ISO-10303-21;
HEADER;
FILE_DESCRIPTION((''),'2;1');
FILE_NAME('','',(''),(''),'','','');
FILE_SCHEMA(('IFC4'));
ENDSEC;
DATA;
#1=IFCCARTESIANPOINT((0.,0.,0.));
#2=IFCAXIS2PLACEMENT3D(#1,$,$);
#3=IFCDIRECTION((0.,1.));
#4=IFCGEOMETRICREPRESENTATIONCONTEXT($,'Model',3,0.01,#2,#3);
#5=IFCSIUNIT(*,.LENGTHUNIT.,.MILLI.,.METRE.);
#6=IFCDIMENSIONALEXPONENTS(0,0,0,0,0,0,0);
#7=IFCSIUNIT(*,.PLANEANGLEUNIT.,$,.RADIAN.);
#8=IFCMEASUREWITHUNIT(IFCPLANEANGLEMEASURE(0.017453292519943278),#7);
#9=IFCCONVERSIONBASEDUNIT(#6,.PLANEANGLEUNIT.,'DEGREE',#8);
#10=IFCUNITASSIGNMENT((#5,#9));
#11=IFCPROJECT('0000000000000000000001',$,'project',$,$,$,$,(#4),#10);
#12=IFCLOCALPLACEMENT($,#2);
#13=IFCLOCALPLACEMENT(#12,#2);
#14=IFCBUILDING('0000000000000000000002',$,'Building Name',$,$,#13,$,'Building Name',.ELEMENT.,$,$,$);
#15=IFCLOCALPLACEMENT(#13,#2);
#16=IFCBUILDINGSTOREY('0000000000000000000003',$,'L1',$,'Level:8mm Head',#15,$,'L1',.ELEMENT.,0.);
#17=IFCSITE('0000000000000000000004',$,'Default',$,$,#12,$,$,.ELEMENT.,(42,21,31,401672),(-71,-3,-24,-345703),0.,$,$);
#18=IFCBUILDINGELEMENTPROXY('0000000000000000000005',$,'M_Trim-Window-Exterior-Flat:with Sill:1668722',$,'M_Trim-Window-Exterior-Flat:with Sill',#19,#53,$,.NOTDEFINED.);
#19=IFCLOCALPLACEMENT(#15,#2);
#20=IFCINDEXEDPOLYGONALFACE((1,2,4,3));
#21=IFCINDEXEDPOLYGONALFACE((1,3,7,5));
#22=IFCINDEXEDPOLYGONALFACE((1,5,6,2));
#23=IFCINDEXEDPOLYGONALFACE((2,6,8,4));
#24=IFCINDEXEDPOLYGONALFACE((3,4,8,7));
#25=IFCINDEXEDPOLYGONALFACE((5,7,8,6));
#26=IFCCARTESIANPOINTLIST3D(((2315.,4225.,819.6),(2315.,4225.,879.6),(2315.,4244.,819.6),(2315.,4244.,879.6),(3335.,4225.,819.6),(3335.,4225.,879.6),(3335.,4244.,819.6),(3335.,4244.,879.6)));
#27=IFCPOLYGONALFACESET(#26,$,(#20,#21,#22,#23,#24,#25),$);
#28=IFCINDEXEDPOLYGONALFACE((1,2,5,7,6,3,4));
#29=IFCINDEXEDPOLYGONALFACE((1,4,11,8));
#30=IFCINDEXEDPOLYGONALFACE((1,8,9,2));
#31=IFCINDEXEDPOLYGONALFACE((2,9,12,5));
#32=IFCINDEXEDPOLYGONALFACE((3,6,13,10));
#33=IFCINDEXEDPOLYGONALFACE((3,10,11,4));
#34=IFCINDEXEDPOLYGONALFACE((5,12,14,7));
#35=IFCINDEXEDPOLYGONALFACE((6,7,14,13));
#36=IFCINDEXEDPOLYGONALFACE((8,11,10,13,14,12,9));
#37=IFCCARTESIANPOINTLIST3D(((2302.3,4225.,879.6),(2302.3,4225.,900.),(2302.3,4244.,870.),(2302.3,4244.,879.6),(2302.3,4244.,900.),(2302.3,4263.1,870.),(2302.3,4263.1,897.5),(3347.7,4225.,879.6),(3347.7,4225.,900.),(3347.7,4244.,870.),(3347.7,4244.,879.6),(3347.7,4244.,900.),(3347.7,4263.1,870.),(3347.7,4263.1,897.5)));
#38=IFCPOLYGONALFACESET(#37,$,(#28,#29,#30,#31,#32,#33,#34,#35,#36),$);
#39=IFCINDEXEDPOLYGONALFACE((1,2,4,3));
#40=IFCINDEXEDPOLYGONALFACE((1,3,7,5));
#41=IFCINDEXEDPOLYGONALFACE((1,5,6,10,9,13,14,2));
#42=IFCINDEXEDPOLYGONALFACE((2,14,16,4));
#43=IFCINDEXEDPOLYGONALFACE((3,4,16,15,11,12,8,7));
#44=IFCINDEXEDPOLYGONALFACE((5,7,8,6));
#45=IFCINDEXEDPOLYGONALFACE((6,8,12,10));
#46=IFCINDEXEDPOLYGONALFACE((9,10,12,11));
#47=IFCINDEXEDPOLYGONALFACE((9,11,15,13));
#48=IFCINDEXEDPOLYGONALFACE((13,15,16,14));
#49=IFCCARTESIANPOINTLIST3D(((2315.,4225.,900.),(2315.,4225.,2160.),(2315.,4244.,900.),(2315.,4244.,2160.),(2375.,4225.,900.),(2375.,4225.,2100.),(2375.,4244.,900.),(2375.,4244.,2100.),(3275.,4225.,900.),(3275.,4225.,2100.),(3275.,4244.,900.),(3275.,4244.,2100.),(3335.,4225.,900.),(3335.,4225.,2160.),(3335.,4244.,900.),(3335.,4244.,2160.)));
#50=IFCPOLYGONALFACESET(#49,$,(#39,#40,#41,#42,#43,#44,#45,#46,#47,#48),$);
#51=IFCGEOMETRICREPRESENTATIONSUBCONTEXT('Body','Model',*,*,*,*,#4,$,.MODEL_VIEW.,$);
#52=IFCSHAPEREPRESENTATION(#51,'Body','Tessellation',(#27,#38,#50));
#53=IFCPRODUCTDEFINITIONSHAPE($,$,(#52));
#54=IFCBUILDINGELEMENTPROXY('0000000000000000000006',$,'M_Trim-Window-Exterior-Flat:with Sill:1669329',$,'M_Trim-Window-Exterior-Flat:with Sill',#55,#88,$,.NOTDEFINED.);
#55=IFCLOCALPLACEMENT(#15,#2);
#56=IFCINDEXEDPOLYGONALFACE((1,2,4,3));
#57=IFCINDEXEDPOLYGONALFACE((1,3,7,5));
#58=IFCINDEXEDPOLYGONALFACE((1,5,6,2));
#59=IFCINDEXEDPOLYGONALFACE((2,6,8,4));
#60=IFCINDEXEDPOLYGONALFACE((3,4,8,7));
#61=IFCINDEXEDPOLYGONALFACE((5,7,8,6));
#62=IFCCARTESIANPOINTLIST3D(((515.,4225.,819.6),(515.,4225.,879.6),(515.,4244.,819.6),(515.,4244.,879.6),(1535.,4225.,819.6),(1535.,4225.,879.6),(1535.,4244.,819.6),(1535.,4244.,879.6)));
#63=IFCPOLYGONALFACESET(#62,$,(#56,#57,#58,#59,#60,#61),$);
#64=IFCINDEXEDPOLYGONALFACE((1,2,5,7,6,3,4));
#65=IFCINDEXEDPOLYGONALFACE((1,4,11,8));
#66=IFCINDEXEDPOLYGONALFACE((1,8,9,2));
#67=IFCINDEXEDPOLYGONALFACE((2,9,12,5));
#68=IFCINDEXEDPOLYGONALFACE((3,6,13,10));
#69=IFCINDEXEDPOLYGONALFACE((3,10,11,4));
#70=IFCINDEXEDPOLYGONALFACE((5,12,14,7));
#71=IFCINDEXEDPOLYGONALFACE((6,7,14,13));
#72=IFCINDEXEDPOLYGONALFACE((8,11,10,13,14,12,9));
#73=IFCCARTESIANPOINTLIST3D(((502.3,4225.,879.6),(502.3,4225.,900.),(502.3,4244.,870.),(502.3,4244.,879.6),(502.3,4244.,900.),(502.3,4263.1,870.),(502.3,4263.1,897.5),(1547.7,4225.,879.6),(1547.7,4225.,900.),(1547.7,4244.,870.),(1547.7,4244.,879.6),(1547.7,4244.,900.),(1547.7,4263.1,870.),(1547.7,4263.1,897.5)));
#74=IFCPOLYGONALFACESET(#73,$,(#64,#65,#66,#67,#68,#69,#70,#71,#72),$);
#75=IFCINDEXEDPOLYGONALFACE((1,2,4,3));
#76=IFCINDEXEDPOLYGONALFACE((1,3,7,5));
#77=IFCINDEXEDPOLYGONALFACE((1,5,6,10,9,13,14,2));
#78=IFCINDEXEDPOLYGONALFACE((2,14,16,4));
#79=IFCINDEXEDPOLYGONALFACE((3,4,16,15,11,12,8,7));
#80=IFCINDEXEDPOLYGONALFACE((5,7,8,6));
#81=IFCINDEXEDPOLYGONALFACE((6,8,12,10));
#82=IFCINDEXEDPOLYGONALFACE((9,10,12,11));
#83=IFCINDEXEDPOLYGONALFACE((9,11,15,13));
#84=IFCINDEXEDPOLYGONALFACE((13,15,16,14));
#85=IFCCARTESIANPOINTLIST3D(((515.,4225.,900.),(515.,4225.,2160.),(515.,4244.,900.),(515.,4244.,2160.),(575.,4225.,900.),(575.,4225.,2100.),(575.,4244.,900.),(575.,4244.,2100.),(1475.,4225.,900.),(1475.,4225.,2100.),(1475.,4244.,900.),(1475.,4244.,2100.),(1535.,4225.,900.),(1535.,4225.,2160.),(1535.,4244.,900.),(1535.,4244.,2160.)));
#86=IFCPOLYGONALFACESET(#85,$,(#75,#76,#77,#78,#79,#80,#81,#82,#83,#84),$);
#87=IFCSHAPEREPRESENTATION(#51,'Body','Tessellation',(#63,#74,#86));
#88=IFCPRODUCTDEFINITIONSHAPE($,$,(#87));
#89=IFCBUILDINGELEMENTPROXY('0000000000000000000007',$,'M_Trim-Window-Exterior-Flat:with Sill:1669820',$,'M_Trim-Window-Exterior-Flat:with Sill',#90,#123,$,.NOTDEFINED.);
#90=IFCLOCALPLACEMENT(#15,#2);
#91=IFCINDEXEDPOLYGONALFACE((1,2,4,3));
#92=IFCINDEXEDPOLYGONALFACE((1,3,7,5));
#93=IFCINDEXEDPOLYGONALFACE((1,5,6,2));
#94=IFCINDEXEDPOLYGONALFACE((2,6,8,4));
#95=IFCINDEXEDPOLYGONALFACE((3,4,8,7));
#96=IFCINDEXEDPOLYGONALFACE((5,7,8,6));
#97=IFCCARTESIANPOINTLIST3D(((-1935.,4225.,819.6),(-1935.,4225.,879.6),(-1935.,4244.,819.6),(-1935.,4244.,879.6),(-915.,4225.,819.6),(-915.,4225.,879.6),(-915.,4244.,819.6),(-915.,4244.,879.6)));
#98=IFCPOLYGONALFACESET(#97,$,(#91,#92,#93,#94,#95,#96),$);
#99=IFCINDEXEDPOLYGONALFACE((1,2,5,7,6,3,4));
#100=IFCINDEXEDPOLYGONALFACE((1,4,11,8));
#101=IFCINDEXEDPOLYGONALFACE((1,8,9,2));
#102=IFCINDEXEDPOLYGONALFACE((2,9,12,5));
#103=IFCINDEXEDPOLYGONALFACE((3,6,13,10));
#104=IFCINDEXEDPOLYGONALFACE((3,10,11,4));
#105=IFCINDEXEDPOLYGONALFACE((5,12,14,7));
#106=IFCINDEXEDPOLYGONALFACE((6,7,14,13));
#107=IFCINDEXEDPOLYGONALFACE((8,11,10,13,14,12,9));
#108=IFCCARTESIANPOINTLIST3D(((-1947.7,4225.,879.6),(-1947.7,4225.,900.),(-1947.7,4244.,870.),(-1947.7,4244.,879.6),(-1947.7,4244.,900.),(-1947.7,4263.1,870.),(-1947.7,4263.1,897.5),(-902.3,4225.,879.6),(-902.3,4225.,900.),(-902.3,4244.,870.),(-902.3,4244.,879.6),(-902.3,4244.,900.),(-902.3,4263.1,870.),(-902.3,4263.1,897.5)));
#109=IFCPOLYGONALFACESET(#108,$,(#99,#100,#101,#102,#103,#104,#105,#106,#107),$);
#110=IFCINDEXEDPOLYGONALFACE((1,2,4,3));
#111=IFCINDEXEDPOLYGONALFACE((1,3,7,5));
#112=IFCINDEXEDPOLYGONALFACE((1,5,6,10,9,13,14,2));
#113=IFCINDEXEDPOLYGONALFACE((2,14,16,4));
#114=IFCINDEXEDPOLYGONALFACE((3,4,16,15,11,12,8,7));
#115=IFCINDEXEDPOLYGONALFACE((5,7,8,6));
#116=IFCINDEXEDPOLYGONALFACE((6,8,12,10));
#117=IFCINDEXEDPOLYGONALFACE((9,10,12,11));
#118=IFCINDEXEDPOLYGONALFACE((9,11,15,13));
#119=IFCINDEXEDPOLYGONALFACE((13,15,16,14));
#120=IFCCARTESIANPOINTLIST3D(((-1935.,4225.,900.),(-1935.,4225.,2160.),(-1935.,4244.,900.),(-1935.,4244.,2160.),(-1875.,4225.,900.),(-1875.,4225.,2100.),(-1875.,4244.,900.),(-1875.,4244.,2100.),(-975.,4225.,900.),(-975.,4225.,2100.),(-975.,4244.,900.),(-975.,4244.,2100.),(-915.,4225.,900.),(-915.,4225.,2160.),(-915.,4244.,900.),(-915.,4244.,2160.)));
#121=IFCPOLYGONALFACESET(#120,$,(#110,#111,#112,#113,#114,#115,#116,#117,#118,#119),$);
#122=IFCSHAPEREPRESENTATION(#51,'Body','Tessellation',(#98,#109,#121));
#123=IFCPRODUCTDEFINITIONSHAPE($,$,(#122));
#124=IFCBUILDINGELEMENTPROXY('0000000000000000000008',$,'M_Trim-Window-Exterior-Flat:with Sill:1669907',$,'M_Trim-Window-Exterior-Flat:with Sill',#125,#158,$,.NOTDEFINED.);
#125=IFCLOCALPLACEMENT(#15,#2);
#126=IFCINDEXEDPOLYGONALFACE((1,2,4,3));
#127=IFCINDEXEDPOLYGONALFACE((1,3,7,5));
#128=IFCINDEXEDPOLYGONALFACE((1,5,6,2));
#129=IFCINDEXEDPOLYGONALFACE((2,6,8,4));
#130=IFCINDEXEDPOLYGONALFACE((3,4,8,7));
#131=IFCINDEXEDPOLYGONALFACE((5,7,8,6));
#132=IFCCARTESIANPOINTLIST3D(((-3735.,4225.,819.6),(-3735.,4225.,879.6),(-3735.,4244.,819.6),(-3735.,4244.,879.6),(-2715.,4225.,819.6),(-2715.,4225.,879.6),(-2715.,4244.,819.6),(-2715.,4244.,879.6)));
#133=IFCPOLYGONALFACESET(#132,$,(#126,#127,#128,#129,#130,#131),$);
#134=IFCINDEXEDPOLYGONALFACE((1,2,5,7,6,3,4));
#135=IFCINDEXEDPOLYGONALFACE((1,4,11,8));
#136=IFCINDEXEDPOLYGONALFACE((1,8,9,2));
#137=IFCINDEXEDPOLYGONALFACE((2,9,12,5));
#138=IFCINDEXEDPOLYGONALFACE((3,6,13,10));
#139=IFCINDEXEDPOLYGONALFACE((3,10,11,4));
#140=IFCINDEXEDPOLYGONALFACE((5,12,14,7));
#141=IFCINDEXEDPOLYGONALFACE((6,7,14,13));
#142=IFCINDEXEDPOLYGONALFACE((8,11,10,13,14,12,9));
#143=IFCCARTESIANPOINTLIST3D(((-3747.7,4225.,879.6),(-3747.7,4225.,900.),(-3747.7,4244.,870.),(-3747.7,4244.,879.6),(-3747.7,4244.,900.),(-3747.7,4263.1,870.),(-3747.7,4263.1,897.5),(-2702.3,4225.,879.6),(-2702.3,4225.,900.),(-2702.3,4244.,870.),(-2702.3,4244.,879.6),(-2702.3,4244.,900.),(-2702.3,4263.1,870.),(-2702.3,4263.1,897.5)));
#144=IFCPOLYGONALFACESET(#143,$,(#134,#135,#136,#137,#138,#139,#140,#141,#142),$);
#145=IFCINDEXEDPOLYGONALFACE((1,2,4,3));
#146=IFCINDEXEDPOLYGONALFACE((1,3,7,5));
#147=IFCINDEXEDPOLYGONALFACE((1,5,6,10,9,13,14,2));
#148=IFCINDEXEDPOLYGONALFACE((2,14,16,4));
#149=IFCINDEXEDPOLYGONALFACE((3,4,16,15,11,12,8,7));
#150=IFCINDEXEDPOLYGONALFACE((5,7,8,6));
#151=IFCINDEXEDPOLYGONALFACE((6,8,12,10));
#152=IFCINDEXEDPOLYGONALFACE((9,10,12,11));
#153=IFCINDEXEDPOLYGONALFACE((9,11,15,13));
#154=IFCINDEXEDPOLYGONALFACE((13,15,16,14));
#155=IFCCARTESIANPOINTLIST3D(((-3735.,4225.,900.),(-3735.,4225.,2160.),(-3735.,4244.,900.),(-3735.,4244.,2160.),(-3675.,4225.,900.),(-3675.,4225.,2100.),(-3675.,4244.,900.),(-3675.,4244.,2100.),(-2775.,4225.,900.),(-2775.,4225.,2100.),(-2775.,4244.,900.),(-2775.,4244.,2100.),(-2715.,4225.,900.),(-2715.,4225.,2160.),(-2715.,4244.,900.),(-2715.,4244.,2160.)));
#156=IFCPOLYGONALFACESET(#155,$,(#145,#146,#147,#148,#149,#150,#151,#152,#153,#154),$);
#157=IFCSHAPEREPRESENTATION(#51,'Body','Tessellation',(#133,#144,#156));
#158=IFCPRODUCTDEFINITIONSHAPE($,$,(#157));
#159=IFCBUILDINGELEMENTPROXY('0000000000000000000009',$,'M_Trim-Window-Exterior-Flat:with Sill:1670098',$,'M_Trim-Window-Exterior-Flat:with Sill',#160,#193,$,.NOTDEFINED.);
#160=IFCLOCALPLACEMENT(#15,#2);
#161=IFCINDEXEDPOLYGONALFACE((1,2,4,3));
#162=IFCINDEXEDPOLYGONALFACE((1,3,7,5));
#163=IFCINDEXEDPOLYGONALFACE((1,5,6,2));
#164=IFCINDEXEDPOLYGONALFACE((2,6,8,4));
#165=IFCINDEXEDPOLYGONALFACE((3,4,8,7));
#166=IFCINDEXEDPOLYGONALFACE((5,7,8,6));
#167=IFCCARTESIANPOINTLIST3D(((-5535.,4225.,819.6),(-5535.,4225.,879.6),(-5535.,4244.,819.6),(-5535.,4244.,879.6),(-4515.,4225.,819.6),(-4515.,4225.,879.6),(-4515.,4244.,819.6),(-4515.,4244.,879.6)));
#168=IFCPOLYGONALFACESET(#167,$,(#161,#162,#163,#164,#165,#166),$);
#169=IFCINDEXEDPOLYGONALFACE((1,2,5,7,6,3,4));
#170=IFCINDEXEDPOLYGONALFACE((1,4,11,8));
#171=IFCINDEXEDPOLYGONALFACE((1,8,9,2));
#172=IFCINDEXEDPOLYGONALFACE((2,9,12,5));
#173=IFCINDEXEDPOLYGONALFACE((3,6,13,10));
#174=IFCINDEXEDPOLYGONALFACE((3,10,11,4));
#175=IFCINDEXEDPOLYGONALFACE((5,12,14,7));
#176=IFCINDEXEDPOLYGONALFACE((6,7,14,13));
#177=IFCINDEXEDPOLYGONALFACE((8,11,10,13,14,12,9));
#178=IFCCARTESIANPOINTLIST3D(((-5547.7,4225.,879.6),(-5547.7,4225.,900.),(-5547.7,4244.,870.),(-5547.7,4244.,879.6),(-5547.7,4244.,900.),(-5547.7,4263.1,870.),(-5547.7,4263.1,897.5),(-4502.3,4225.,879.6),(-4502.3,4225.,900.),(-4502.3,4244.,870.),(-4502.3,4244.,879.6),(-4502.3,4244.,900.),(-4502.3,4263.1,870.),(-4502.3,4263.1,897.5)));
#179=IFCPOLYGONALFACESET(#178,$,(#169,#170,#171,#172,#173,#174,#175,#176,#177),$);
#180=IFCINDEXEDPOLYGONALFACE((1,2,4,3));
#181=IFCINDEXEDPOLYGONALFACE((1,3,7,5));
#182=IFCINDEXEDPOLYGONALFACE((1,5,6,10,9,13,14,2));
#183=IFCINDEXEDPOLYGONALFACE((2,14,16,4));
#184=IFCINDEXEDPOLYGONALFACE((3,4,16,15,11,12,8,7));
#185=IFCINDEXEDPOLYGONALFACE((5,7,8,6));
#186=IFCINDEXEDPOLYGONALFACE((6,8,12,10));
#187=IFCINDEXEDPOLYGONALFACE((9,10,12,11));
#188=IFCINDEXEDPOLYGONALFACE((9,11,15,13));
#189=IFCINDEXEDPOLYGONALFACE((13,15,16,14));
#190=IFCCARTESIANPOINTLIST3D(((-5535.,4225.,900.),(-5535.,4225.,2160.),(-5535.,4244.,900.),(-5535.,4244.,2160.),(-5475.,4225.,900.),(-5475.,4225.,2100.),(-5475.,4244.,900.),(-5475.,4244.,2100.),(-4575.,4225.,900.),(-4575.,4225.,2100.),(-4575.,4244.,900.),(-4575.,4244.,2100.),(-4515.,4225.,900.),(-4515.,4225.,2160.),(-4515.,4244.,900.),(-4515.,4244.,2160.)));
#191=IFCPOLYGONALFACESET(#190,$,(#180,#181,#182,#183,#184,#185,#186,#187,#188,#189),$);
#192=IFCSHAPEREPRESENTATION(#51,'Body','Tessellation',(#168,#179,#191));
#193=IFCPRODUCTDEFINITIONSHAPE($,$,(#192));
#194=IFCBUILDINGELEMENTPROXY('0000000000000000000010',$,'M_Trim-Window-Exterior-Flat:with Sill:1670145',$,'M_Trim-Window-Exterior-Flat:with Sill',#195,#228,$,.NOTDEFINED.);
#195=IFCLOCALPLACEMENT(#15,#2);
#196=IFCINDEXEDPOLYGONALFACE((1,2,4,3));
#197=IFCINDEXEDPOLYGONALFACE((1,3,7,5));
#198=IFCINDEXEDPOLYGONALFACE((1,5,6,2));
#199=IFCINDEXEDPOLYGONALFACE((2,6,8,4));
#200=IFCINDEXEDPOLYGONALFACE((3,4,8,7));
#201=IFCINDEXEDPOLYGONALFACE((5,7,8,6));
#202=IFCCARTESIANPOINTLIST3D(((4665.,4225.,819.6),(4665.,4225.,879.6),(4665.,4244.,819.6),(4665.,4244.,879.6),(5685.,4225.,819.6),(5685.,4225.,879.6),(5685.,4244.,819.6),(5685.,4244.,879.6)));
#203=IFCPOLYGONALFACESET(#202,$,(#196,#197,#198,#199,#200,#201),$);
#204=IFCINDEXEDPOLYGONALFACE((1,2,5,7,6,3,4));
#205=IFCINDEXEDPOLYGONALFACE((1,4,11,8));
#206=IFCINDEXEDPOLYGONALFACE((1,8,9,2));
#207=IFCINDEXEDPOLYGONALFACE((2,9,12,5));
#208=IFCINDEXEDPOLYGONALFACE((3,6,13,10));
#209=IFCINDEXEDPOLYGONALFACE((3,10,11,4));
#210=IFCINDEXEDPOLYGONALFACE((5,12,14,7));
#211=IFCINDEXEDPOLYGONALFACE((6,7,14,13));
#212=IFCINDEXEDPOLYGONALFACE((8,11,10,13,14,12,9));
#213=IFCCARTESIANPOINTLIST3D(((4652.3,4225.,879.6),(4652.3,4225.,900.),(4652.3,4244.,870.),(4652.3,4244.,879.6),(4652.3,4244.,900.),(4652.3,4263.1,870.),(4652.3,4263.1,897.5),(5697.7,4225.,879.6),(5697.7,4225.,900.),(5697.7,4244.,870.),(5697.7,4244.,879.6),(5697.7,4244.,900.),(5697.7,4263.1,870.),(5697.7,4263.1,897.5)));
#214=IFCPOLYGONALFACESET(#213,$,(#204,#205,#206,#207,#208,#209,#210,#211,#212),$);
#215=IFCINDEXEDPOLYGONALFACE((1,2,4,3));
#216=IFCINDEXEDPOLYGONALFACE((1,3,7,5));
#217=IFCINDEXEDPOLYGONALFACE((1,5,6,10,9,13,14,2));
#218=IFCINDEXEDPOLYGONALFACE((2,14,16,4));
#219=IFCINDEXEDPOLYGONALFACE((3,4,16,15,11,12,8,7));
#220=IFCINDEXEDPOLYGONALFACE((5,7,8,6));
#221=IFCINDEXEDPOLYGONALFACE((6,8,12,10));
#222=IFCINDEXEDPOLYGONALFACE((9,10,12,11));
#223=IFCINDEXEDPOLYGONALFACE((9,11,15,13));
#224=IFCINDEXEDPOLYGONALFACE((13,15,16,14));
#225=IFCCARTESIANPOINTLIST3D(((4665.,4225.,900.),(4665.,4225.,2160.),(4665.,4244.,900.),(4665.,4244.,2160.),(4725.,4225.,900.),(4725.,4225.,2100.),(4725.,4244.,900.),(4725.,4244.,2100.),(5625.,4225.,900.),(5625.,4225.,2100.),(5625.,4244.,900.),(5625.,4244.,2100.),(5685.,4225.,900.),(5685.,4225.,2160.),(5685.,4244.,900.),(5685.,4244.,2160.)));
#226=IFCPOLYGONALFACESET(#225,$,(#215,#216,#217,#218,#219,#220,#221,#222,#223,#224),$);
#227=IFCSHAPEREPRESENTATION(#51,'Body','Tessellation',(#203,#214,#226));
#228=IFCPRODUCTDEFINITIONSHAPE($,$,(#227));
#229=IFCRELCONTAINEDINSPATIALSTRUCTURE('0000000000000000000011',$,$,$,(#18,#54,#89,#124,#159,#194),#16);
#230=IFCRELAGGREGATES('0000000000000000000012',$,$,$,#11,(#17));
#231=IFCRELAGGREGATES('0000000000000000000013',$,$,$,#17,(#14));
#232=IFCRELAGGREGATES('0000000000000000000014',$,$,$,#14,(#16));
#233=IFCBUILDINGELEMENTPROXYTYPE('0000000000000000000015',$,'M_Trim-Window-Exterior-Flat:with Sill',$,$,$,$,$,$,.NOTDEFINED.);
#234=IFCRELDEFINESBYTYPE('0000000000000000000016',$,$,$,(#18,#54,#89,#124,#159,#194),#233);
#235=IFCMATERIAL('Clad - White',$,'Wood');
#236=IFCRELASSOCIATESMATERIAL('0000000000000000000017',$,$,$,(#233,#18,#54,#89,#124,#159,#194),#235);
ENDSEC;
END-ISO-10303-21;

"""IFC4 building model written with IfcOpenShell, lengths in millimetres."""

from ifc_helpers import new_model, entity, si_unit, converted_unit, direction, frame, frame_2d, origin, place, context, subcontext, project, spatial, polyline, rectangle, outline, extrude, source, transform, mapped, material, type_object, type_shapes, element, save


model = new_model("IFC4")

# Units and contexts
model_context = context("Model", 3, precision=0.01, world=origin(), true_north=direction((0.0, 1.0)))
body_context = subcontext(model_context, "Body", "Model", "MODEL_VIEW")
ifc_project = project(units=[si_unit("LENGTHUNIT", "METRE", prefix="MILLI"), converted_unit("PLANEANGLEUNIT", "DEGREE", entity("IfcPlaneAngleMeasure", 0.017453292519943278), si_unit("PLANEANGLEUNIT", "RADIAN"), dimensions=[0, 0, 0, 0, 0, 0, 0])], contexts=[model_context])

# Site, building, storey
site_placement = place(None, origin())
site = spatial("IfcSite", under=ifc_project, at=site_placement, Name="Default", CompositionType="ELEMENT", RefLatitude=(42, 21, 31, 401672), RefLongitude=(-71, -3, -24, -345703), RefElevation=0.0)
building_placement = place(site_placement, origin())
building = spatial("IfcBuilding", under=site, at=building_placement, Name="Building Name", LongName="Building Name", CompositionType="ELEMENT")
storey_placement = place(building_placement, origin())
storey = spatial("IfcBuildingStorey", under=building, at=storey_placement, Name="L1", ObjectType="Level:8mm Head", LongName="L1", CompositionType="ELEMENT", Elevation=0.0)

# Building element proxies
ifc_material_1 = material(Name="Clad - White", Category="Wood")
building_element_proxy_type_1 = type_object("IfcBuildingElementProxyType", Name="M_Trim-Window-Exterior-Flat:with Sill", PredefinedType="NOTDEFINED", material=ifc_material_1)
shared_shape_1 = source(origin(), body_context, "Body", "SweptSolid", [
    extrude(rectangle(XDim=1020.0, YDim=60.0, at=frame_2d((0.0, 0.0), x_axis=(1.0, 0.0))), frame((0.0, -1250.4, 0.0), z_axis=(0.0, 0.0, 1.0), x_axis=(-1.0, 0.0, 0.0)), (0.0, 0.0, 1.0), 19.0),
    extrude(outline(polyline([(-19.0, -15.2), (0.0, -15.2), (0.0, -5.7), (19.0, -5.7), (19.0, 14.8), (0.0, 14.8), (-19.0, 12.3), (-19.0, -15.2)])), frame((-522.7, -1214.8, 19.0), z_axis=(1.0, 0.0, 0.0), x_axis=(0.0, 0.0, -1.0)), (0.0, 0.0, 1.0), 1045.4),
    extrude(outline(polyline([(-645.0, -510.0), (615.0, -510.0), (615.0, -450.0), (-585.0, -450.0), (-585.0, 450.0), (615.0, 450.0), (615.0, 510.0), (-645.0, 510.0), (-645.0, -510.0)])), frame((0.0, -585.0, 0.0), z_axis=(0.0, 0.0, 1.0), x_axis=(0.0, -1.0, 0.0)), (0.0, 0.0, 1.0), 19.0),
])
type_shapes(building_element_proxy_type_1, [shared_shape_1])
for number, where, z_axis, x_axis, name in (
    (1, (2825.0, 4225.0, 2100.0), (0.0, 1.0, 0.0), (-1.0, 0.0, 0.0), "M_Trim-Window-Exterior-Flat:with Sill:1668722"),
    (2, (1025.0, 4225.0, 2100.0), (0.0, 1.0, 0.0), (-1.0, 0.0, 0.0), "M_Trim-Window-Exterior-Flat:with Sill:1669329"),
    (3, (-1425.0, 4225.0, 2100.0), (0.0, 1.0, 0.0), (-1.0, 0.0, 0.0), "M_Trim-Window-Exterior-Flat:with Sill:1669820"),
    (4, (-3225.0, 4225.0, 2100.0), (0.0, 1.0, 0.0), (-1.0, 0.0, 0.0), "M_Trim-Window-Exterior-Flat:with Sill:1669907"),
    (5, (-5025.0, 4225.0, 2100.0), (0.0, 1.0, 0.0), (-1.0, 0.0, 0.0), "M_Trim-Window-Exterior-Flat:with Sill:1670098"),
    (6, (5175.0, 4225.0, 2100.0), (0.0, 1.0, 0.0), (-1.0, 0.0, 0.0), "M_Trim-Window-Exterior-Flat:with Sill:1670145"),
):
    element("IfcBuildingElementProxy", number, at=place(storey_placement, frame(where, z_axis=z_axis, x_axis=x_axis)), inside=storey, type_object=building_element_proxy_type_1, material=ifc_material_1, Name=name, ObjectType="M_Trim-Window-Exterior-Flat:with Sill", PredefinedType="NOTDEFINED", context=body_context, shape_type="MappedRepresentation", body=[
        mapped(shared_shape_1, transform((0.0, 0.0, 0.0), scale=1.0)),
    ])

save(model, "model.ifc")
